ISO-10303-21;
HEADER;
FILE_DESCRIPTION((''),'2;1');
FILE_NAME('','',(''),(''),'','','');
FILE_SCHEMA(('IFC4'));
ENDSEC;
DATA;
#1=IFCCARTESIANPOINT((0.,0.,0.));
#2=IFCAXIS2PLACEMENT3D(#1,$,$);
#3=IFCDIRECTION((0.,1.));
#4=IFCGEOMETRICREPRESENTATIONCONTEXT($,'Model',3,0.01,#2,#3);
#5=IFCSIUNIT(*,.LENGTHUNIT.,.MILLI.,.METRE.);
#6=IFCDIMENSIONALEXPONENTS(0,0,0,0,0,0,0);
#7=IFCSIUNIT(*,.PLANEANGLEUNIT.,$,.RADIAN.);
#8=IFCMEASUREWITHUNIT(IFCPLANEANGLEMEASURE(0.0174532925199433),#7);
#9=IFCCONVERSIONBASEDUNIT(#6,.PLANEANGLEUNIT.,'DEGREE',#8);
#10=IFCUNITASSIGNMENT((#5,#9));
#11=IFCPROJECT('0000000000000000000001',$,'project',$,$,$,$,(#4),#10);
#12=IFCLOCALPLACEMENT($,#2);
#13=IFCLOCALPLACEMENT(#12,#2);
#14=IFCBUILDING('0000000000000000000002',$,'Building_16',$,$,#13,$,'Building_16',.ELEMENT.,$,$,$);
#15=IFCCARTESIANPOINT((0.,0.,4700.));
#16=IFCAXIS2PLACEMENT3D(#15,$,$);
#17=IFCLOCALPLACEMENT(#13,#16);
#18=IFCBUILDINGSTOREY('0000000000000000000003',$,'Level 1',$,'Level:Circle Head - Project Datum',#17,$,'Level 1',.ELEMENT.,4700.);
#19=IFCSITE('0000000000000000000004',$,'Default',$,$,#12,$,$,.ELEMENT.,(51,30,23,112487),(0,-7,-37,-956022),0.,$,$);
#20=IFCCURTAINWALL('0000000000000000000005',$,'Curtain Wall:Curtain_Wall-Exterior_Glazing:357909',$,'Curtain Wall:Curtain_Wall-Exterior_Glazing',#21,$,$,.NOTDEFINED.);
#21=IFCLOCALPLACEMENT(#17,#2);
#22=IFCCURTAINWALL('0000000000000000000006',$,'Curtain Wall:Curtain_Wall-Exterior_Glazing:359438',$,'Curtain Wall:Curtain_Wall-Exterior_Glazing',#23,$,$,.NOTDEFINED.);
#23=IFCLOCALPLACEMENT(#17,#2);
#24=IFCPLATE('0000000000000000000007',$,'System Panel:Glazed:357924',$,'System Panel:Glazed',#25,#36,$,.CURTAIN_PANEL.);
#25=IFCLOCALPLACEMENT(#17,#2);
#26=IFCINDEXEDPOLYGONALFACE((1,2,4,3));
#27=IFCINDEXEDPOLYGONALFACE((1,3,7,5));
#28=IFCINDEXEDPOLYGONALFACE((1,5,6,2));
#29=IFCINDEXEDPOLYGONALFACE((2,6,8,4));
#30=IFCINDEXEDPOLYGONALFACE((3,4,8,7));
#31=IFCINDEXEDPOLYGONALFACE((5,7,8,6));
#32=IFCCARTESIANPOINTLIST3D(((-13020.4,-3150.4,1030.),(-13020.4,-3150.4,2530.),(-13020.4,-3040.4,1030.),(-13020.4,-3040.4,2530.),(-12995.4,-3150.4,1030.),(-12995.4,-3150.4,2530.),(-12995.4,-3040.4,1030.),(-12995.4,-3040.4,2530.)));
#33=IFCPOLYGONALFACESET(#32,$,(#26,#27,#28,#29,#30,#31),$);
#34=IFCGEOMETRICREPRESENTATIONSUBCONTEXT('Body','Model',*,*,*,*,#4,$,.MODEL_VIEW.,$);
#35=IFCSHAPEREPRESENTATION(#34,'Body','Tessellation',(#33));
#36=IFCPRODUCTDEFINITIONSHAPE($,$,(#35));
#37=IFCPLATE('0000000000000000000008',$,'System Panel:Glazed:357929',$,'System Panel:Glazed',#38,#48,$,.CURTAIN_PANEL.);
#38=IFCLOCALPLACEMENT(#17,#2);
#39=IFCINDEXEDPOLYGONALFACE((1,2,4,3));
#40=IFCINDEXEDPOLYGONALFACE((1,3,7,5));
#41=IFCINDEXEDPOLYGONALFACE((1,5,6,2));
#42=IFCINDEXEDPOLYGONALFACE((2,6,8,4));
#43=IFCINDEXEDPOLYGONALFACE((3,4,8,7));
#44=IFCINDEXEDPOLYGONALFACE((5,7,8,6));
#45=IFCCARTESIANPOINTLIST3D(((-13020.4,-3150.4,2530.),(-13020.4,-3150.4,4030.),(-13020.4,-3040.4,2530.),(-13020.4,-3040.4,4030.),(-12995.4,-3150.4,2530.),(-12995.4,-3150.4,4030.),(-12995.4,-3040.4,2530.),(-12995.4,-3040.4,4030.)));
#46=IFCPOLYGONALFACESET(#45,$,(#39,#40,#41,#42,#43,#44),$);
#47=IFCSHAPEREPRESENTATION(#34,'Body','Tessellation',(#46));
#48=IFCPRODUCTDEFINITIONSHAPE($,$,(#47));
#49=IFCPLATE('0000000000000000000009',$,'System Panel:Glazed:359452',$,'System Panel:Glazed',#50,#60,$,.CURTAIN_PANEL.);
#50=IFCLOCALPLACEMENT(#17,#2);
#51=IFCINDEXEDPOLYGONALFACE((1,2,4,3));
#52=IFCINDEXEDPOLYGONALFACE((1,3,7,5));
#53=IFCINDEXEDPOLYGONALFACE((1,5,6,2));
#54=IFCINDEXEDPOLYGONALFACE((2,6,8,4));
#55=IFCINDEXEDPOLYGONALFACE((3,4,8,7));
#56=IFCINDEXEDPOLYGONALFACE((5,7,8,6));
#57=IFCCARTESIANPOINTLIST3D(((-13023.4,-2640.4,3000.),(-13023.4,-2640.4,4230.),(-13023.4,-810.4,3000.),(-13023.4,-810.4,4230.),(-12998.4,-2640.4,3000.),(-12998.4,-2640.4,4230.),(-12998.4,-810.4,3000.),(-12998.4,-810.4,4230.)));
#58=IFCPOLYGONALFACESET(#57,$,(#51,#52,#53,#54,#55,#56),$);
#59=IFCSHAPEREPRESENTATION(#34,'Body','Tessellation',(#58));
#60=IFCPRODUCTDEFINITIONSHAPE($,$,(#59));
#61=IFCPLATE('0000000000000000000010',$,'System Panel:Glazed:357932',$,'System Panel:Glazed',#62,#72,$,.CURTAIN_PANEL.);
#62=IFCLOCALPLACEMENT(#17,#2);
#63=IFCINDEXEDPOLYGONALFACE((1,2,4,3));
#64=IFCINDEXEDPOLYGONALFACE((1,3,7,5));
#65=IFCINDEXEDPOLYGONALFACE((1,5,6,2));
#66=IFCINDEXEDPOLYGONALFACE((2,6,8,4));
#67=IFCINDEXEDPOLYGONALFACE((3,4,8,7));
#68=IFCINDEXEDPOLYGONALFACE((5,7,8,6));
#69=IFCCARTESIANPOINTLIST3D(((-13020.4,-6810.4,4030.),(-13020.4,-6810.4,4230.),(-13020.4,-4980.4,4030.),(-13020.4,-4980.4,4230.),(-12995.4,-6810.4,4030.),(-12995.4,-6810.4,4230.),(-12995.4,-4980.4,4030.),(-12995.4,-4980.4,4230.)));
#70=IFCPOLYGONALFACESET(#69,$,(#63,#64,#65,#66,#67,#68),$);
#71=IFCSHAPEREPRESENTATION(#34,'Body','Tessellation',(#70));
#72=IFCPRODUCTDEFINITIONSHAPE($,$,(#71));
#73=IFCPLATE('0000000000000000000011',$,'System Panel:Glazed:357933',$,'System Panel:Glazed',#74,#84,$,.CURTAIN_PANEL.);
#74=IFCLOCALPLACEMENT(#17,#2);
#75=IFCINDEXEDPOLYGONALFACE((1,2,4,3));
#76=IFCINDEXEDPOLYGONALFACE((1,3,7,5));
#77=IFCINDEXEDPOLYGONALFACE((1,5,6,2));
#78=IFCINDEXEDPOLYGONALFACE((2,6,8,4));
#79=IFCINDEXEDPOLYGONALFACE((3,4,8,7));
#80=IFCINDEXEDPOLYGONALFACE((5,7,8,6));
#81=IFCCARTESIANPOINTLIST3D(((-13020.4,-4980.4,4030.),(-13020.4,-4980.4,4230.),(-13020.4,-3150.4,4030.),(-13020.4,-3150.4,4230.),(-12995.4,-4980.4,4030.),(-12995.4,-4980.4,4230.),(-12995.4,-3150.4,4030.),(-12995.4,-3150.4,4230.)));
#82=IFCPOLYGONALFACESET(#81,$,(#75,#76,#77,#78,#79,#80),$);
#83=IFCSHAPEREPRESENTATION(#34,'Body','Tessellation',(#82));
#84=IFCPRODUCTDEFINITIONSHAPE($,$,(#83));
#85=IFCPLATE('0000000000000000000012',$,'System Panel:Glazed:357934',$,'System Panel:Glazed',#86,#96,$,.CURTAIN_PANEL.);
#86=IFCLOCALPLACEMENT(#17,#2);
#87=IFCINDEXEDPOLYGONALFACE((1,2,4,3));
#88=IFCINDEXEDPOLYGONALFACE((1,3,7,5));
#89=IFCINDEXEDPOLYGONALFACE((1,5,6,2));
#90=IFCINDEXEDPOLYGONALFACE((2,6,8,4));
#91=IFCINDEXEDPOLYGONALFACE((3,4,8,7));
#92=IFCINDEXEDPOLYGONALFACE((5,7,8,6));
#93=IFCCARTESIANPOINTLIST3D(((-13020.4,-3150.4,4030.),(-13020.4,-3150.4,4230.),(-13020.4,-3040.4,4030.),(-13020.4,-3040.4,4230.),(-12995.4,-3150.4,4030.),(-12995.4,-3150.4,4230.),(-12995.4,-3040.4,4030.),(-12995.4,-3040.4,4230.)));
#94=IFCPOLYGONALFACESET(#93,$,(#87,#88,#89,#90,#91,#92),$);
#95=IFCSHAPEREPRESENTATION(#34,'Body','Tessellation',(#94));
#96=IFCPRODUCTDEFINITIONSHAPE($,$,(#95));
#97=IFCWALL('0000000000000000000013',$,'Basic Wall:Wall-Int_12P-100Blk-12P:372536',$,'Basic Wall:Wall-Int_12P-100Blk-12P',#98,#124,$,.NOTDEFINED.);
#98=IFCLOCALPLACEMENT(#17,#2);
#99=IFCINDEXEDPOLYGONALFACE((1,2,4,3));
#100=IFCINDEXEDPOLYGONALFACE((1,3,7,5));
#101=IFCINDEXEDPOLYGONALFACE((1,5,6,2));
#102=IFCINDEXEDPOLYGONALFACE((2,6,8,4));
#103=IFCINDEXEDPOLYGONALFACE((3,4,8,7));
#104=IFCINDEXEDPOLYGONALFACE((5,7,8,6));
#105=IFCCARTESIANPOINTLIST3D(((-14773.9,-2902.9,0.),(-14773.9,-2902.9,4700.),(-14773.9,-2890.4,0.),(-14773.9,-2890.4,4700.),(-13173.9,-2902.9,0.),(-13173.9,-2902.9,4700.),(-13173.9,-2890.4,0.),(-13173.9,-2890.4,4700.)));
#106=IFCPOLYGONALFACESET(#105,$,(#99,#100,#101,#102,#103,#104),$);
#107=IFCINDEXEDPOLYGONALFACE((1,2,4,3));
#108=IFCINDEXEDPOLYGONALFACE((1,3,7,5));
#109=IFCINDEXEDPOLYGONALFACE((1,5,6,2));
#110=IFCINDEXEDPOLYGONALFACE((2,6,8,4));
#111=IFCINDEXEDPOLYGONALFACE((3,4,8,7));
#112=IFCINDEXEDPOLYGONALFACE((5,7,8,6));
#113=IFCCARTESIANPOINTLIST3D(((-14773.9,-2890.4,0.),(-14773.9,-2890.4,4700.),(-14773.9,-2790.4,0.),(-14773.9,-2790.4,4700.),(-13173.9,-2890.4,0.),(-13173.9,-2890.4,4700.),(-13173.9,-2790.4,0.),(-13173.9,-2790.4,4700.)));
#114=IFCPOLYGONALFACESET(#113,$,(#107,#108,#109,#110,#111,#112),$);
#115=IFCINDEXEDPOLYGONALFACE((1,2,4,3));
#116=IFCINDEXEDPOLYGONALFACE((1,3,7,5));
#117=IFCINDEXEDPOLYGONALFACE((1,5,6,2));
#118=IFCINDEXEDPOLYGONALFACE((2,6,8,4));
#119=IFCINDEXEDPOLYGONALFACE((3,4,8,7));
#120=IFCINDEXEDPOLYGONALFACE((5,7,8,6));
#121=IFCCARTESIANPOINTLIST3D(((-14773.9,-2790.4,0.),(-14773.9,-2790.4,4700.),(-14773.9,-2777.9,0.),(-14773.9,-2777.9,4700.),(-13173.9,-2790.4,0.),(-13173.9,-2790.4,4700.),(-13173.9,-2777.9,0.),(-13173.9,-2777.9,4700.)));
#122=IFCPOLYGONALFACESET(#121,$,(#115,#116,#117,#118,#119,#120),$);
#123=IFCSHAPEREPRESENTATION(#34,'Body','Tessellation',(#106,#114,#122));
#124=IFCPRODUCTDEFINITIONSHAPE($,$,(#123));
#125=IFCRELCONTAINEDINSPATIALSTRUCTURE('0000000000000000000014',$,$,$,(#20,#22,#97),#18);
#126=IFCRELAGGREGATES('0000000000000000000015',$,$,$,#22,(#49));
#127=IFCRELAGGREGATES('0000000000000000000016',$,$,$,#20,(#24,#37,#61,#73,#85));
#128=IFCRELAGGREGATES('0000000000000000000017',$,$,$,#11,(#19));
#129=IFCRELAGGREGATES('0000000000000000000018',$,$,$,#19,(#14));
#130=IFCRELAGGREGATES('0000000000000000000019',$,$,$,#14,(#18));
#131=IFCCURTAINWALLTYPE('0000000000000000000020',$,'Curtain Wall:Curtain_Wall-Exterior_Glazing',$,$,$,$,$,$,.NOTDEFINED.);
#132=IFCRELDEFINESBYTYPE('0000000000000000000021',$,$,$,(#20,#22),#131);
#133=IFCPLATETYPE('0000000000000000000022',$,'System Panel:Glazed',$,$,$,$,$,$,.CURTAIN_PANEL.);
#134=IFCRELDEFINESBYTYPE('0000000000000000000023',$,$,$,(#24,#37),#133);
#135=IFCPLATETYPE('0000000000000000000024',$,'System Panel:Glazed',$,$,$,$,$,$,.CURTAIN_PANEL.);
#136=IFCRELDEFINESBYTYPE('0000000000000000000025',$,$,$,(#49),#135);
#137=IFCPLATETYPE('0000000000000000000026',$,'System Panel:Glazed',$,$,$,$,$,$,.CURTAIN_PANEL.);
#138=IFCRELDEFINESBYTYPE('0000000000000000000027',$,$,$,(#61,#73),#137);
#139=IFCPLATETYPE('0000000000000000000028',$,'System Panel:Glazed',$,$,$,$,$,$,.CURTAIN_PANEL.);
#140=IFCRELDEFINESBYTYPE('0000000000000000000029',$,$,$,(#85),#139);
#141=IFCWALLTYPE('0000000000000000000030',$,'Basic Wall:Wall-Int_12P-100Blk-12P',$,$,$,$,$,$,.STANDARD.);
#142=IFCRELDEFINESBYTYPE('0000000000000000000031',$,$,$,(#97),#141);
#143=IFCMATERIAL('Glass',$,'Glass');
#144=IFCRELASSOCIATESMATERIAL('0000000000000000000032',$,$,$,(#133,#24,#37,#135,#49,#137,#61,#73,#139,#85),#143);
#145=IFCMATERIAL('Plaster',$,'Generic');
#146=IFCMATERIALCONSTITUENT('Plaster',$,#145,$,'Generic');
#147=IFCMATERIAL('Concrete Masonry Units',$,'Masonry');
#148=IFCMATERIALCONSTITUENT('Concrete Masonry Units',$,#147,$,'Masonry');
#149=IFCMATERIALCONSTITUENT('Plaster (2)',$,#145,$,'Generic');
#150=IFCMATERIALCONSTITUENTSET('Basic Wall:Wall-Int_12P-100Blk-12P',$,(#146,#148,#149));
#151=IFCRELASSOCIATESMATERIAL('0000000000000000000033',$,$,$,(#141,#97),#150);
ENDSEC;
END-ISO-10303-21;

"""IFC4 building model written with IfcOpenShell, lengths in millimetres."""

from ifc_helpers import new_model, entity, si_unit, converted_unit, direction, frame, origin, place, context, subcontext, project, spatial, indexed_curve, outline, extrude, source, transform, mapped, material, constituent, constituent_set, type_object, type_shapes, element, aggregate, save


model = new_model("IFC4")

# Units and contexts
model_context = context("Model", 3, precision=0.01, world=origin(), true_north=direction((0.0, 1.0)))
body_context = subcontext(model_context, "Body", "Model", "MODEL_VIEW")
ifc_project = project(units=[si_unit("LENGTHUNIT", "METRE", prefix="MILLI"), converted_unit("PLANEANGLEUNIT", "DEGREE", entity("IfcPlaneAngleMeasure", 0.0174532925199433), si_unit("PLANEANGLEUNIT", "RADIAN"), dimensions=[0, 0, 0, 0, 0, 0, 0])], contexts=[model_context])

# Site, building, storey
site_placement = place(None, origin())
site = spatial("IfcSite", under=ifc_project, at=site_placement, Name="Default", CompositionType="ELEMENT", RefLatitude=(51, 30, 23, 112487), RefLongitude=(0, -7, -37, -956022), RefElevation=0.0)
building_placement = place(site_placement, origin())
building = spatial("IfcBuilding", under=site, at=building_placement, Name="Building_16", LongName="Building_16", CompositionType="ELEMENT")
storey_placement = place(building_placement, frame((0.0, 0.0, 4700.0)))
storey = spatial("IfcBuildingStorey", under=building, at=storey_placement, Name="Level 1", ObjectType="Level:Circle Head - Project Datum", LongName="Level 1", CompositionType="ELEMENT", Elevation=4700.0)

# Shared definitions
ifc_material_1 = material(Name="Plaster", Category="Generic")

# Curtain walls
curtain_wall_type = type_object("IfcCurtainWallType", Name="Curtain Wall:Curtain_Wall-Exterior_Glazing", PredefinedType="NOTDEFINED")
curtain_wall_1_placement = place(storey_placement, frame((0.0, 0.0, -4700.0)))
curtain_wall_1 = element("IfcCurtainWall", 1, at=curtain_wall_1_placement, inside=storey, type_object=curtain_wall_type, Name="Curtain Wall:Curtain_Wall-Exterior_Glazing:357909", ObjectType="Curtain Wall:Curtain_Wall-Exterior_Glazing", PredefinedType="NOTDEFINED")
ifc_material_2 = material(Name="Glass", Category="Glass")
curtain_wall_2_placement = place(storey_placement, frame((0.0, 0.0, -4700.0)))
curtain_wall_2 = element("IfcCurtainWall", 2, at=curtain_wall_2_placement, inside=storey, type_object=curtain_wall_type, Name="Curtain Wall:Curtain_Wall-Exterior_Glazing:359438", ObjectType="Curtain Wall:Curtain_Wall-Exterior_Glazing", PredefinedType="NOTDEFINED")

# Plates
plate_type_1 = type_object("IfcPlateType", Name="System Panel:Glazed", PredefinedType="CURTAIN_PANEL", material=ifc_material_2)
shared_shape_1 = source(origin(), body_context, "Body", "SweptSolid", [
    extrude(outline(indexed_curve([(-12.5, -55.0), (12.5, -55.0), (12.5, 55.0), (-12.5, 55.0), (-12.5, -55.0)], self_intersect=False)), frame((0.0, 37.0, 0.0), z_axis=(0.0, 0.0, 1.0), x_axis=(0.0, 1.0, 0.0)), (0.0, 0.0, 1.0), 1500.0),
])
type_shapes(plate_type_1, [shared_shape_1])
plate_1_placement = place(curtain_wall_1_placement, frame((-12970.9, -3095.4, 5730.0), z_axis=(0.0, 0.0, 1.0), x_axis=(0.0, 1.0, 0.0)))
plate_1 = element("IfcPlate", 3, at=plate_1_placement, type_object=plate_type_1, material=ifc_material_2, Name="System Panel:Glazed:357924", ObjectType="System Panel:Glazed", PredefinedType="CURTAIN_PANEL", context=body_context, shape_type="MappedRepresentation", body=[
    mapped(shared_shape_1, transform((0.0, 0.0, 0.0), scale=1.0)),
])
plate_2_placement = place(curtain_wall_1_placement, frame((-12970.9, -3095.4, 7230.0), z_axis=(0.0, 0.0, 1.0), x_axis=(0.0, 1.0, 0.0)))
plate_2 = element("IfcPlate", 4, at=plate_2_placement, type_object=plate_type_1, material=ifc_material_2, Name="System Panel:Glazed:357929", ObjectType="System Panel:Glazed", PredefinedType="CURTAIN_PANEL", context=body_context, shape_type="MappedRepresentation", body=[
    mapped(shared_shape_1, transform((0.0, 0.0, 0.0), scale=1.0)),
])
plate_type_2 = type_object("IfcPlateType", Name="System Panel:Glazed", PredefinedType="CURTAIN_PANEL", material=ifc_material_2)
shared_shape_2 = source(origin(), body_context, "Body", "SweptSolid", [
    extrude(outline(indexed_curve([(-12.5, -915.0), (12.5, -915.0), (12.5, 915.0), (-12.5, 915.0), (-12.5, -915.0)], self_intersect=False)), frame((0.0, 37.0, 0.0), z_axis=(0.0, 0.0, 1.0), x_axis=(0.0, 1.0, 0.0)), (0.0, 0.0, 1.0), 1230.0),
])
type_shapes(plate_type_2, [shared_shape_2])
plate_3_placement = place(curtain_wall_2_placement, frame((-12973.9, -1725.4, 7700.0), z_axis=(0.0, 0.0, 1.0), x_axis=(0.0, 1.0, 0.0)))
plate_3 = element("IfcPlate", 5, at=plate_3_placement, type_object=plate_type_2, material=ifc_material_2, Name="System Panel:Glazed:359452", ObjectType="System Panel:Glazed", PredefinedType="CURTAIN_PANEL", context=body_context, shape_type="MappedRepresentation", body=[
    mapped(shared_shape_2, transform((0.0, 0.0, 0.0), scale=1.0)),
])
aggregate(curtain_wall_2, [plate_3])
plate_type_3 = type_object("IfcPlateType", Name="System Panel:Glazed", PredefinedType="CURTAIN_PANEL", material=ifc_material_2)
shared_shape_3 = source(origin(), body_context, "Body", "SweptSolid", [
    extrude(outline(indexed_curve([(-12.5, -915.0), (12.5, -915.0), (12.5, 915.0), (-12.5, 915.0), (-12.5, -915.0)], self_intersect=False)), frame((0.0, 37.0, 0.0), z_axis=(0.0, 0.0, 1.0), x_axis=(0.0, 1.0, 0.0)), (0.0, 0.0, 1.0), 200.0),
])
type_shapes(plate_type_3, [shared_shape_3])
plate_4_placement = place(curtain_wall_1_placement, frame((-12970.9, -5895.4, 8730.0), z_axis=(0.0, 0.0, 1.0), x_axis=(0.0, 1.0, 0.0)))
plate_4 = element("IfcPlate", 6, at=plate_4_placement, type_object=plate_type_3, material=ifc_material_2, Name="System Panel:Glazed:357932", ObjectType="System Panel:Glazed", PredefinedType="CURTAIN_PANEL", context=body_context, shape_type="MappedRepresentation", body=[
    mapped(shared_shape_3, transform((0.0, 0.0, 0.0), scale=1.0)),
])
plate_5_placement = place(curtain_wall_1_placement, frame((-12970.9, -4065.4, 8730.0), z_axis=(0.0, 0.0, 1.0), x_axis=(0.0, 1.0, 0.0)))
plate_5 = element("IfcPlate", 7, at=plate_5_placement, type_object=plate_type_3, material=ifc_material_2, Name="System Panel:Glazed:357933", ObjectType="System Panel:Glazed", PredefinedType="CURTAIN_PANEL", context=body_context, shape_type="MappedRepresentation", body=[
    mapped(shared_shape_3, transform((0.0, 0.0, 0.0), scale=1.0)),
])
plate_type_4 = type_object("IfcPlateType", Name="System Panel:Glazed", PredefinedType="CURTAIN_PANEL", material=ifc_material_2)
shared_shape_4 = source(origin(), body_context, "Body", "SweptSolid", [
    extrude(outline(indexed_curve([(-12.5, -55.0), (12.5, -55.0), (12.5, 55.0), (-12.5, 55.0), (-12.5, -55.0)], self_intersect=False)), frame((0.0, 37.0, 0.0), z_axis=(0.0, 0.0, 1.0), x_axis=(0.0, 1.0, 0.0)), (0.0, 0.0, 1.0), 200.0),
])
type_shapes(plate_type_4, [shared_shape_4])
plate_6_placement = place(curtain_wall_1_placement, frame((-12970.9, -3095.4, 8730.0), z_axis=(0.0, 0.0, 1.0), x_axis=(0.0, 1.0, 0.0)))
plate_6 = element("IfcPlate", 8, at=plate_6_placement, type_object=plate_type_4, material=ifc_material_2, Name="System Panel:Glazed:357934", ObjectType="System Panel:Glazed", PredefinedType="CURTAIN_PANEL", context=body_context, shape_type="MappedRepresentation", body=[
    mapped(shared_shape_4, transform((0.0, 0.0, 0.0), scale=1.0)),
])
aggregate(curtain_wall_1, [plate_1, plate_2, plate_4, plate_5, plate_6])

# Wall
ifc_constituent_1 = constituent(ifc_material_1, Name="Plaster", Category="Generic")
ifc_material_3 = material(Name="Concrete Masonry Units", Category="Masonry")
ifc_constituent_2 = constituent(ifc_material_3, Name="Concrete Masonry Units", Category="Masonry")
ifc_constituent_3 = constituent(ifc_material_1, Name="Plaster (2)", Category="Generic")
ifc_constituent_set = constituent_set(constituents=[ifc_constituent_1, ifc_constituent_2, ifc_constituent_3], Name="Basic Wall:Wall-Int_12P-100Blk-12P")
wall_type = type_object("IfcWallType", Name="Basic Wall:Wall-Int_12P-100Blk-12P", PredefinedType="STANDARD", material=ifc_constituent_set)
wall_placement = place(storey_placement, frame((-14773.9, -2840.4, 0.0)))
element("IfcWall", 9, at=wall_placement, inside=storey, type_object=wall_type, material=ifc_constituent_set, Name="Basic Wall:Wall-Int_12P-100Blk-12P:372536", ObjectType="Basic Wall:Wall-Int_12P-100Blk-12P", PredefinedType="NOTDEFINED", context=body_context, shape_type="SweptSolid", body=[
    extrude(outline(indexed_curve([(-6.3, -800.0), (6.2, -800.0), (6.3, 800.0), (-6.2, 800.0), (-6.3, -800.0)], self_intersect=False)), frame((800.0, -56.3, 0.0), z_axis=(0.0, 0.0, 1.0), x_axis=(0.0, 1.0, 0.0)), (0.0, 0.0, 1.0), 4700.0),
    extrude(outline(indexed_curve([(-800.0, -50.0), (800.0, -50.0), (800.0, 50.0), (-800.0, 50.0), (-800.0, -50.0)], self_intersect=False)), frame((800.0, 0.0, 0.0)), (0.0, 0.0, 1.0), 4700.0),
    extrude(outline(indexed_curve([(-6.3, -800.0), (6.2, -800.0), (6.3, 800.0), (-6.2, 800.0), (-6.3, -800.0)], self_intersect=False)), frame((800.0, 56.2, 0.0), z_axis=(0.0, 0.0, 1.0), x_axis=(0.0, -1.0, 0.0)), (0.0, 0.0, 1.0), 4700.0),
])

save(model, "model.ifc")
